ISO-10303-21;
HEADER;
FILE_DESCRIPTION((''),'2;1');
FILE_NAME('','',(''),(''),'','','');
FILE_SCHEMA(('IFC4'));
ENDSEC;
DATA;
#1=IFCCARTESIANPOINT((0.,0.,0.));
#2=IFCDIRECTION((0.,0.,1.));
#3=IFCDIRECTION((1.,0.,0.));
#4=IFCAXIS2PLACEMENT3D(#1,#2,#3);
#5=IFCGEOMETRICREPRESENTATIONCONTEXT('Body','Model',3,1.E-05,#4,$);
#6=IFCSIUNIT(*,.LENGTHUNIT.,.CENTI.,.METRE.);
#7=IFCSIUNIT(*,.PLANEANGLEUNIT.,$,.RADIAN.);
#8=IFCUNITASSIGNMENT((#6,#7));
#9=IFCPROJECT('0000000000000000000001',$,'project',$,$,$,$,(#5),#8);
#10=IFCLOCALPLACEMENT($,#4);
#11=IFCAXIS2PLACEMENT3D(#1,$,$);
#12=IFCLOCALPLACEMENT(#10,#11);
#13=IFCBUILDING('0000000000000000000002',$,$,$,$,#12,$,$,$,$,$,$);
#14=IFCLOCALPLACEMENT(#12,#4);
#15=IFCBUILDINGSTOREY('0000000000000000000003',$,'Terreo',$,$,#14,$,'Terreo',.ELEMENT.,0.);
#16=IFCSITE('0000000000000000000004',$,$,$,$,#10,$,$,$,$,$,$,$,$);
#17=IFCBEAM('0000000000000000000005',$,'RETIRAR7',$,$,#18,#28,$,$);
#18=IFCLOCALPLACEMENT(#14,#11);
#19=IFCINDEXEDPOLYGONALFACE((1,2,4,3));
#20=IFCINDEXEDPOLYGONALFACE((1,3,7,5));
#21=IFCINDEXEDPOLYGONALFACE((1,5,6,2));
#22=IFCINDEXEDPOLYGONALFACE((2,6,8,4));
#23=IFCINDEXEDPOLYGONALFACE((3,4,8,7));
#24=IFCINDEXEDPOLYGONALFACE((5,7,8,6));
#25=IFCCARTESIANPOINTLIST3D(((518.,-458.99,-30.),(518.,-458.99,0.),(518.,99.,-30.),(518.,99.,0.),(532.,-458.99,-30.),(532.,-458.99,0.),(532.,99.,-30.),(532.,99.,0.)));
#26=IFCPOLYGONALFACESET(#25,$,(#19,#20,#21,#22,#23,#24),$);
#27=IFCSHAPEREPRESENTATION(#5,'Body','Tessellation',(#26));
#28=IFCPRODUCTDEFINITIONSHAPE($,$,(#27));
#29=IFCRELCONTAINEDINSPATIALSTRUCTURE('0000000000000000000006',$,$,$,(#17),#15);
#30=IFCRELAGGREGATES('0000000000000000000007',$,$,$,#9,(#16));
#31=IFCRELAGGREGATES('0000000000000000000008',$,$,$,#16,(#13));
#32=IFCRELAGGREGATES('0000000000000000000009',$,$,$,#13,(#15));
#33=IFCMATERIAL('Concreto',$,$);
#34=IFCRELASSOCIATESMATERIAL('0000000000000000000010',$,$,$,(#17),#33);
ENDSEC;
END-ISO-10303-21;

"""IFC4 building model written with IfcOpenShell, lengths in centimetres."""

from ifc_helpers import new_model, si_unit, frame, origin, origin_with_axes, origin_2d_with_axis, place, context, project, spatial, rectangle, extrude, material, element, save


model = new_model("IFC4")

# Units and contexts
model_context = context("Model", 3, precision=1e-05, world=origin_with_axes(), identifier="Body")
ifc_project = project(units=[si_unit("LENGTHUNIT", "METRE", prefix="CENTI"), si_unit("PLANEANGLEUNIT", "RADIAN")], contexts=[model_context])

# Site, building, storey
site_placement = place(None, origin_with_axes())
site = spatial("IfcSite", under=ifc_project, at=site_placement)
building_placement = place(site_placement, origin())
building = spatial("IfcBuilding", under=site, at=building_placement)
storey_placement = place(building_placement, origin_with_axes())
storey = spatial("IfcBuildingStorey", under=building, at=storey_placement, Name="Terreo", LongName="Terreo", CompositionType="ELEMENT", Elevation=0.0)

# Shared definitions
ifc_material = material(Name="Concreto")

# Beam
beam_1_placement = place(storey_placement, frame((525.0, -180.0, 0.0), z_axis=(0.0, 0.0, 1.0), x_axis=(1.0, 0.0, 0.0)))
element("IfcBeam", 1, at=beam_1_placement, inside=storey, material=ifc_material, Name="RETIRAR7", context=model_context, shape_type="SolidModel", body=[
    extrude(rectangle(XDim=14.0, YDim=30.0, at=origin_2d_with_axis()), frame((0.0, -279.0, -15.0), z_axis=(0.0, 1.0, 0.0), x_axis=(1.0, 0.0, 0.0)), (0.0, 0.0, 1.0), 557.99),
])

save(model, "model.ifc")
